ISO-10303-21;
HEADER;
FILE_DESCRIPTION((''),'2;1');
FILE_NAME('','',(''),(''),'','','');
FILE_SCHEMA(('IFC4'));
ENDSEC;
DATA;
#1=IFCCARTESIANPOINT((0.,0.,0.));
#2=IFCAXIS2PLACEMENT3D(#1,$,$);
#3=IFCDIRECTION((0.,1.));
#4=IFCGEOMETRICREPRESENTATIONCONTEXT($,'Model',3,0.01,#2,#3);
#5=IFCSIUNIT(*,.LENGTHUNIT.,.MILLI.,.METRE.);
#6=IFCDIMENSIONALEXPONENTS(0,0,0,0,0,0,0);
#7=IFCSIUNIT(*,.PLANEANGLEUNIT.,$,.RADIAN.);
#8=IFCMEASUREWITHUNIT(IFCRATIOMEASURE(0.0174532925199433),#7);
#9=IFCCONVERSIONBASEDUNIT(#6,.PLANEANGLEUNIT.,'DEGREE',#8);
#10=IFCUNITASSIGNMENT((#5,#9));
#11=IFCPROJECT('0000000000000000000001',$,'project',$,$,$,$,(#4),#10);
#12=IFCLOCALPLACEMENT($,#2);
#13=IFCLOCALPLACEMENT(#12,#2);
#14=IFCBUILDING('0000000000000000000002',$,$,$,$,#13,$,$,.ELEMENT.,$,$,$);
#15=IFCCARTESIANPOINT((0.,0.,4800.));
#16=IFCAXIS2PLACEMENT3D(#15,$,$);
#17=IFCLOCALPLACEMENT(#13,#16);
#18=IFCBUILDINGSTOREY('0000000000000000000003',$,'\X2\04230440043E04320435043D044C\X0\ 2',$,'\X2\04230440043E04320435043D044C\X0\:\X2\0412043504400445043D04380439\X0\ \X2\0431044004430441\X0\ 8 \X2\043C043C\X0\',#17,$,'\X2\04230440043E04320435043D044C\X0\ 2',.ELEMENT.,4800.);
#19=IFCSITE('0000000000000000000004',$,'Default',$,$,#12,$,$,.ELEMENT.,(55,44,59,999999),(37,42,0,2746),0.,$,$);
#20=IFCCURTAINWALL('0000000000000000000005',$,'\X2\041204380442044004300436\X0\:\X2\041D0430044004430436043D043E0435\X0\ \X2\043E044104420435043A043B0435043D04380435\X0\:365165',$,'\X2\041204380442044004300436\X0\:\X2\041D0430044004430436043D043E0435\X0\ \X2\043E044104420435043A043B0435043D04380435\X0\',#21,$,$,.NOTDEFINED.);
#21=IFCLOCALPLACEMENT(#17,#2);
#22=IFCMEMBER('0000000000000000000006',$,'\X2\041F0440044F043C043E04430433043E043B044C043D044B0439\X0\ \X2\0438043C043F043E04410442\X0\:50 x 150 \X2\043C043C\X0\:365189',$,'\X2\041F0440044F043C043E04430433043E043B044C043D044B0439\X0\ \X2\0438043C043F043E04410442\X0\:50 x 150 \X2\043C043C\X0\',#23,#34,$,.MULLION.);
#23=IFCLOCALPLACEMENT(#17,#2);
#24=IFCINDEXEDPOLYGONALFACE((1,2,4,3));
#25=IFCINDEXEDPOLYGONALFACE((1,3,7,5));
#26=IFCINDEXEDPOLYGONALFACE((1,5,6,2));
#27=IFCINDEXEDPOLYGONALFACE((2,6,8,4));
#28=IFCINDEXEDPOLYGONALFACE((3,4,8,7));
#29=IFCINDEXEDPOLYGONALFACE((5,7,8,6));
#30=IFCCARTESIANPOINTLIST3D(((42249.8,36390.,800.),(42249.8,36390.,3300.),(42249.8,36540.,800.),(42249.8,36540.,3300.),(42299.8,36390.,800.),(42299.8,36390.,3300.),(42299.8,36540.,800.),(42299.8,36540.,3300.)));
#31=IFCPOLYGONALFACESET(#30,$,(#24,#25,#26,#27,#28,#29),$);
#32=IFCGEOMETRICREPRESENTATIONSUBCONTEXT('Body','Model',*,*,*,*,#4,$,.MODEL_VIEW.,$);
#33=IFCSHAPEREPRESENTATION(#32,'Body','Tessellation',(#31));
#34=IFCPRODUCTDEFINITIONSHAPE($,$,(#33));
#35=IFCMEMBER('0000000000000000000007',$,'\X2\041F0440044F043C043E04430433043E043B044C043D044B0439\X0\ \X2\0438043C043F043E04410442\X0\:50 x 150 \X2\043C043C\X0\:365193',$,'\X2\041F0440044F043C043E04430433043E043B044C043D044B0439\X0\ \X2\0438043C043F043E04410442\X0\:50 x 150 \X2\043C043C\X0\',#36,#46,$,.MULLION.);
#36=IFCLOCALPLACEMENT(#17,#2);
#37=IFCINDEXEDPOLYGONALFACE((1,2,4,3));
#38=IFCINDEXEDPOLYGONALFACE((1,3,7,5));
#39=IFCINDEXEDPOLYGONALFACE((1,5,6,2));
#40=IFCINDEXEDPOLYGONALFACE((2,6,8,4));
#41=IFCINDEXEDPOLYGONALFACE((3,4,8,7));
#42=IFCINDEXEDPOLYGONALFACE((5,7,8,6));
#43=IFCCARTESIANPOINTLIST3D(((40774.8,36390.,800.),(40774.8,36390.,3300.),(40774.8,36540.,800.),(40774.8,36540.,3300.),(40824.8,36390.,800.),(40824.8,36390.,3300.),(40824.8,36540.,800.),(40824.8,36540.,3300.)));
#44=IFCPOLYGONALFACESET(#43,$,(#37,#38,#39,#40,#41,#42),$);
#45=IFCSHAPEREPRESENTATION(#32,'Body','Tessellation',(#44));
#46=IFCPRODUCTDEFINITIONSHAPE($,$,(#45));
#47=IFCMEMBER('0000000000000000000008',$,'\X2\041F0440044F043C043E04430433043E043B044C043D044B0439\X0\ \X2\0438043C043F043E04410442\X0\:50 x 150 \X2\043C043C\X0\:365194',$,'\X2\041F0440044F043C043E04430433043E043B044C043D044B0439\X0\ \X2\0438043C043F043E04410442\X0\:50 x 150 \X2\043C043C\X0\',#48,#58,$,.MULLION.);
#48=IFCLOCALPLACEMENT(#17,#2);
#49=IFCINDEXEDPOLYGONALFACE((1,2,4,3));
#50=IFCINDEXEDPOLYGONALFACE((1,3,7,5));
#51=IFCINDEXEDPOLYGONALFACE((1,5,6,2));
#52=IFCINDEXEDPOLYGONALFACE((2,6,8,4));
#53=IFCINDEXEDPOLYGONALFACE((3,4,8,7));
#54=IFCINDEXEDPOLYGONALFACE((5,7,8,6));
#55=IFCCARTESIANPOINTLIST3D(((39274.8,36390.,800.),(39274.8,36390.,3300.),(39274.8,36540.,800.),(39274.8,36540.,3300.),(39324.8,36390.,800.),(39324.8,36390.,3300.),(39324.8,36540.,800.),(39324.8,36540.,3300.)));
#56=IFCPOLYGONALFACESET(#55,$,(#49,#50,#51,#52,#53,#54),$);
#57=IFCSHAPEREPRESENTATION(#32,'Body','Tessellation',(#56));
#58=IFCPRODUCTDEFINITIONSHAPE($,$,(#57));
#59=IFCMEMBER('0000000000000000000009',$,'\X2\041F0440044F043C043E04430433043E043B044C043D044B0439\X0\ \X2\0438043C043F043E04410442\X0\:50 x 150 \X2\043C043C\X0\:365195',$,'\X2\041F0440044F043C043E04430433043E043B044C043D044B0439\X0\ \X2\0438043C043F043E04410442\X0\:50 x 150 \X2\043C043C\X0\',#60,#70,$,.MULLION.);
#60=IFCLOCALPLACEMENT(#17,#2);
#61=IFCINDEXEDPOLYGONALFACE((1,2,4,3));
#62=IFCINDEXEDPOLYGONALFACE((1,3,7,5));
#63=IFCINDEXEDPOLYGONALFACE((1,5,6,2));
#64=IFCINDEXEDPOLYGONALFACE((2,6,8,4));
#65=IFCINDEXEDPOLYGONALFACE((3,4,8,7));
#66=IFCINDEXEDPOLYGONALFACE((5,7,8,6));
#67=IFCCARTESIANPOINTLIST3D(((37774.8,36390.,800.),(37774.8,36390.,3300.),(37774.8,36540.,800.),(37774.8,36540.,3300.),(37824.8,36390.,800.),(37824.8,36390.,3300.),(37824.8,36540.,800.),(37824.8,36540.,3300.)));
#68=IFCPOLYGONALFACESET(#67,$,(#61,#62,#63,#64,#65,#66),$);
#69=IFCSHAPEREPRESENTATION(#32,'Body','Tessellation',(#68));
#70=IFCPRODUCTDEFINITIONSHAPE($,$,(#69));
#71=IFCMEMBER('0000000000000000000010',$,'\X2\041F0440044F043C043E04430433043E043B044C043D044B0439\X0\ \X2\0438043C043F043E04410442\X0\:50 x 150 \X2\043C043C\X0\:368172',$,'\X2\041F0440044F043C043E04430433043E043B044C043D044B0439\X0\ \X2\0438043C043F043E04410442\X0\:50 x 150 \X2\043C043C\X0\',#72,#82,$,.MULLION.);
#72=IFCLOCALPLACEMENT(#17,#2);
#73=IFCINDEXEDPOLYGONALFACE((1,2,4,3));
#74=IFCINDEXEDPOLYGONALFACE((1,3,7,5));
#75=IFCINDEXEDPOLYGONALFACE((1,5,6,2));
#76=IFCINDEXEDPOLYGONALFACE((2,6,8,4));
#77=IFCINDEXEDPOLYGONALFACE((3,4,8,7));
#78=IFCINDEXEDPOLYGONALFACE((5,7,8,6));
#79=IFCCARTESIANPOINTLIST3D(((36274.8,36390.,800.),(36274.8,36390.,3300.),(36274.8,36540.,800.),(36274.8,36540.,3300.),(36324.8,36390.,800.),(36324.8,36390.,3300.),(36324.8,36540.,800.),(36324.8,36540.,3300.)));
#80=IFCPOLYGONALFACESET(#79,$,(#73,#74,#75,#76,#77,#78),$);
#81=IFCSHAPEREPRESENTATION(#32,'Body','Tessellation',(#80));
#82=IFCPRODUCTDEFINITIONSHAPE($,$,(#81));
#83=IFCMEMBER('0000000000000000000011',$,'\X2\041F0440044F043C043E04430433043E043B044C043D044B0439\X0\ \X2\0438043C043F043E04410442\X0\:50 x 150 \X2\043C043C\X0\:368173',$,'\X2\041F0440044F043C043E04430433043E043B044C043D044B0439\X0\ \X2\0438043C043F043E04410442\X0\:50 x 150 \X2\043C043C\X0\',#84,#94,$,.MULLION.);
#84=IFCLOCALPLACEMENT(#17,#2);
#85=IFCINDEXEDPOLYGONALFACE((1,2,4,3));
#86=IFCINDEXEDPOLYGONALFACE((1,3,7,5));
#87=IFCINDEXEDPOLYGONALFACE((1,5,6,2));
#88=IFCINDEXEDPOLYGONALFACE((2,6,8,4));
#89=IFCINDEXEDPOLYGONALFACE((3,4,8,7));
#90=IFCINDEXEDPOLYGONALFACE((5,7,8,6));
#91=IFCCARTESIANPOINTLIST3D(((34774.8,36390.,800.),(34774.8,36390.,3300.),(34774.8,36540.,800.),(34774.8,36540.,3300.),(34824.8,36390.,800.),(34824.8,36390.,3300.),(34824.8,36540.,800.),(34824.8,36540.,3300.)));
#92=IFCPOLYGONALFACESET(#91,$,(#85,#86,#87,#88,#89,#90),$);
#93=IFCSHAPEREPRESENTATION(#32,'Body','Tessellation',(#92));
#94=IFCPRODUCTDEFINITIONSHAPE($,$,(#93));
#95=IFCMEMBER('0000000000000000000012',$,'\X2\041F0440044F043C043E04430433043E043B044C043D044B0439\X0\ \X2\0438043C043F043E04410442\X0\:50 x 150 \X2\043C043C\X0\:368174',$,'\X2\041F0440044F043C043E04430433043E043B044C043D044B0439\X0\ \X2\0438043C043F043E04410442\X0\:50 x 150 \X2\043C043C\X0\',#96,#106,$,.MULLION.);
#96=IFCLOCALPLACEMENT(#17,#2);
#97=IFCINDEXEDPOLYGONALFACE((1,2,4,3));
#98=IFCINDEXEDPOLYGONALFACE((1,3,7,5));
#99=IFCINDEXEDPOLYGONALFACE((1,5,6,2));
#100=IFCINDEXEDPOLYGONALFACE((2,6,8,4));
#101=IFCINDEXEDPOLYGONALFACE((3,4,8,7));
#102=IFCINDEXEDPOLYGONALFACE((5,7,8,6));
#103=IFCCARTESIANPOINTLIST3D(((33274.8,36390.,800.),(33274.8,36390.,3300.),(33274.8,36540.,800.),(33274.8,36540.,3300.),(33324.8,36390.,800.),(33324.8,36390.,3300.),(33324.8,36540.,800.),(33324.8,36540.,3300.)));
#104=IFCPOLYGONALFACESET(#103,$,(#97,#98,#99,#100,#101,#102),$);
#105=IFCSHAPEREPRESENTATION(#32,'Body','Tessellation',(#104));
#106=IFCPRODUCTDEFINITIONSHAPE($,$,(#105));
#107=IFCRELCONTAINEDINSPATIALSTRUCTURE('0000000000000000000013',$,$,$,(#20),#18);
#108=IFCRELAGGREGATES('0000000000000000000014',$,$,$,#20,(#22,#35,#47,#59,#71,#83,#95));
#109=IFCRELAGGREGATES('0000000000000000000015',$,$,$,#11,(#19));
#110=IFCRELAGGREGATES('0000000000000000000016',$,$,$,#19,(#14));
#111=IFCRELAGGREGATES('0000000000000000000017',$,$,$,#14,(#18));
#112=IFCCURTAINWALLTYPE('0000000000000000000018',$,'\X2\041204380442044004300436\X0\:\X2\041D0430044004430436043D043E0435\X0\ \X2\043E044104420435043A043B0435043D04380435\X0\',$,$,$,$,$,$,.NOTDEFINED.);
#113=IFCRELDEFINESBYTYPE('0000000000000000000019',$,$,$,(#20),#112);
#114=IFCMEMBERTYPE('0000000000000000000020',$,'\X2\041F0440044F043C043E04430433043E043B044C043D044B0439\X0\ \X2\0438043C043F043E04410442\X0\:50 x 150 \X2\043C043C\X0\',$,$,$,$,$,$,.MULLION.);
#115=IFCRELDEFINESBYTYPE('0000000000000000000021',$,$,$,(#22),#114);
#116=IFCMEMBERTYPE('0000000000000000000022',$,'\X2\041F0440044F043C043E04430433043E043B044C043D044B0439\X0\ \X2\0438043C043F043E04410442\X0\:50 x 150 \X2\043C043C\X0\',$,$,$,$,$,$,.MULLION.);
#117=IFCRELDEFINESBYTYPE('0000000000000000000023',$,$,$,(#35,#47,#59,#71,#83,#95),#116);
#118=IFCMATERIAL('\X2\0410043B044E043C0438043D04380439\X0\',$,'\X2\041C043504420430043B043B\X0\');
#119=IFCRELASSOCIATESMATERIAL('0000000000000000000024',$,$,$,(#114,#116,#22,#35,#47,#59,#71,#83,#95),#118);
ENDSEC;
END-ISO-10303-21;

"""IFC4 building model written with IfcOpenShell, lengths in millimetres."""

from ifc_helpers import new_model, entity, si_unit, converted_unit, direction, frame, origin, origin_2d_with_axis, place, context, subcontext, project, spatial, rectangle, extrude, source, transform, mapped, material, material_profile, profile_set, profile_usage, type_object, type_shapes, element, aggregate, save


model = new_model("IFC4")

# Units and contexts
model_context = context("Model", 3, precision=0.01, world=origin(), true_north=direction((0.0, 1.0)))
body_context = subcontext(model_context, "Body", "Model", "MODEL_VIEW")
ifc_project = project(units=[si_unit("LENGTHUNIT", "METRE", prefix="MILLI"), converted_unit("PLANEANGLEUNIT", "DEGREE", entity("IfcRatioMeasure", 0.0174532925199433), si_unit("PLANEANGLEUNIT", "RADIAN"), dimensions=[0, 0, 0, 0, 0, 0, 0])], contexts=[model_context])

# Site, building, storey
site_placement = place(None, origin())
site = spatial("IfcSite", under=ifc_project, at=site_placement, Name="Default", CompositionType="ELEMENT", RefLatitude=(55, 44, 59, 999999), RefLongitude=(37, 42, 0, 2746), RefElevation=0.0)
building_placement = place(site_placement, origin())
building = spatial("IfcBuilding", under=site, at=building_placement, CompositionType="ELEMENT")
storey_placement = place(building_placement, frame((0.0, 0.0, 4800.0)))
storey = spatial("IfcBuildingStorey", under=building, at=storey_placement, Name="Уровень 2", ObjectType="Уровень:Верхний брус 8 мм", LongName="Уровень 2", CompositionType="ELEMENT", Elevation=4800.0)

# Curtain wall, members
curtain_wall_type = type_object("IfcCurtainWallType", Name="Витраж:Наружное остекление", PredefinedType="NOTDEFINED")
curtain_wall_placement = place(storey_placement, frame((0.0, 0.0, -4800.0)))
curtain_wall = element("IfcCurtainWall", 1, at=curtain_wall_placement, inside=storey, type_object=curtain_wall_type, Name="Витраж:Наружное остекление:365165", ObjectType="Витраж:Наружное остекление", PredefinedType="NOTDEFINED")
ifc_material_1 = material(Name="Алюминий", Category="Металл")
ifc_material_profile = material_profile(ifc_material_1, rectangle(XDim=150.0, YDim=50.0, at=origin_2d_with_axis()), Name="50 x 150 мм")
ifc_profile_set = profile_set([ifc_material_profile], Name="50 x 150 мм")
ifc_profile_usage_1 = profile_usage(ifc_profile_set)
member_type_1 = type_object("IfcMemberType", Name="Прямоугольный импост:50 x 150 мм", PredefinedType="MULLION", material=ifc_profile_set)
shared_shape_1 = source(origin(), body_context, "Body", "SweptSolid", [
    extrude(rectangle(XDim=150.0, YDim=50.0, at=origin_2d_with_axis()), frame((-25.0, 0.0, -2500.0), z_axis=(0.0, 0.0, 1.0), x_axis=(0.0, -1.0, 0.0)), (0.0, 0.0, 1.0), 2500.0),
])
type_shapes(member_type_1, [shared_shape_1])
member_1_placement = place(storey_placement, frame((42299.8, 36465.0, 3300.0)))
member_1 = element("IfcMember", 2, at=member_1_placement, type_object=member_type_1, material=ifc_profile_usage_1, Name="Прямоугольный импост:50 x 150 мм:365189", ObjectType="Прямоугольный импост:50 x 150 мм", PredefinedType="MULLION", context=body_context, shape_type="MappedRepresentation", body=[
    mapped(shared_shape_1, transform((0.0, 0.0, 0.0), scale=1.0)),
])
ifc_profile_usage_2 = profile_usage(ifc_profile_set)
member_type_2 = type_object("IfcMemberType", Name="Прямоугольный импост:50 x 150 мм", PredefinedType="MULLION", material=ifc_profile_set)
shared_shape_2 = source(origin(), body_context, "Body", "SweptSolid", [
    extrude(rectangle(XDim=150.0, YDim=50.0, at=origin_2d_with_axis()), frame((0.0, 0.0, -2500.0), z_axis=(0.0, 0.0, 1.0), x_axis=(0.0, -1.0, 0.0)), (0.0, 0.0, 1.0), 2500.0),
])
type_shapes(member_type_2, [shared_shape_2])
member_2_placement = place(storey_placement, frame((40799.8, 36465.0, 800.0), z_axis=(0.0, 0.0, -1.0), x_axis=(-1.0, 0.0, 0.0)))
member_2 = element("IfcMember", 3, at=member_2_placement, type_object=member_type_2, material=ifc_profile_usage_2, Name="Прямоугольный импост:50 x 150 мм:365193", ObjectType="Прямоугольный импост:50 x 150 мм", PredefinedType="MULLION", context=body_context, shape_type="MappedRepresentation", body=[
    mapped(shared_shape_2, transform((0.0, 0.0, 0.0), scale=1.0)),
])
ifc_profile_usage_3 = profile_usage(ifc_profile_set)
member_3_placement = place(storey_placement, frame((39299.8, 36465.0, 800.0), z_axis=(0.0, 0.0, -1.0), x_axis=(-1.0, 0.0, 0.0)))
member_3 = element("IfcMember", 4, at=member_3_placement, type_object=member_type_2, material=ifc_profile_usage_3, Name="Прямоугольный импост:50 x 150 мм:365194", ObjectType="Прямоугольный импост:50 x 150 мм", PredefinedType="MULLION", context=body_context, shape_type="MappedRepresentation", body=[
    mapped(shared_shape_2, transform((0.0, 0.0, 0.0), scale=1.0)),
])
ifc_profile_usage_4 = profile_usage(ifc_profile_set)
member_4_placement = place(storey_placement, frame((37799.8, 36465.0, 800.0), z_axis=(0.0, 0.0, -1.0), x_axis=(-1.0, 0.0, 0.0)))
member_4 = element("IfcMember", 5, at=member_4_placement, type_object=member_type_2, material=ifc_profile_usage_4, Name="Прямоугольный импост:50 x 150 мм:365195", ObjectType="Прямоугольный импост:50 x 150 мм", PredefinedType="MULLION", context=body_context, shape_type="MappedRepresentation", body=[
    mapped(shared_shape_2, transform((0.0, 0.0, 0.0), scale=1.0)),
])
ifc_profile_usage_5 = profile_usage(ifc_profile_set)
member_5_placement = place(storey_placement, frame((36299.8, 36465.0, 800.0), z_axis=(0.0, 0.0, -1.0), x_axis=(-1.0, 0.0, 0.0)))
member_5 = element("IfcMember", 6, at=member_5_placement, type_object=member_type_2, material=ifc_profile_usage_5, Name="Прямоугольный импост:50 x 150 мм:368172", ObjectType="Прямоугольный импост:50 x 150 мм", PredefinedType="MULLION", context=body_context, shape_type="MappedRepresentation", body=[
    mapped(shared_shape_2, transform((0.0, 0.0, 0.0), scale=1.0)),
])
ifc_profile_usage_6 = profile_usage(ifc_profile_set)
member_6_placement = place(storey_placement, frame((34799.8, 36465.0, 800.0), z_axis=(0.0, 0.0, -1.0), x_axis=(-1.0, 0.0, 0.0)))
member_6 = element("IfcMember", 7, at=member_6_placement, type_object=member_type_2, material=ifc_profile_usage_6, Name="Прямоугольный импост:50 x 150 мм:368173", ObjectType="Прямоугольный импост:50 x 150 мм", PredefinedType="MULLION", context=body_context, shape_type="MappedRepresentation", body=[
    mapped(shared_shape_2, transform((0.0, 0.0, 0.0), scale=1.0)),
])
ifc_profile_usage_7 = profile_usage(ifc_profile_set)
member_7_placement = place(storey_placement, frame((33299.8, 36465.0, 800.0), z_axis=(0.0, 0.0, -1.0), x_axis=(-1.0, 0.0, 0.0)))
member_7 = element("IfcMember", 8, at=member_7_placement, type_object=member_type_2, material=ifc_profile_usage_7, Name="Прямоугольный импост:50 x 150 мм:368174", ObjectType="Прямоугольный импост:50 x 150 мм", PredefinedType="MULLION", context=body_context, shape_type="MappedRepresentation", body=[
    mapped(shared_shape_2, transform((0.0, 0.0, 0.0), scale=1.0)),
])
aggregate(curtain_wall, [member_1, member_2, member_3, member_4, member_5, member_6, member_7])

save(model, "model.ifc")
